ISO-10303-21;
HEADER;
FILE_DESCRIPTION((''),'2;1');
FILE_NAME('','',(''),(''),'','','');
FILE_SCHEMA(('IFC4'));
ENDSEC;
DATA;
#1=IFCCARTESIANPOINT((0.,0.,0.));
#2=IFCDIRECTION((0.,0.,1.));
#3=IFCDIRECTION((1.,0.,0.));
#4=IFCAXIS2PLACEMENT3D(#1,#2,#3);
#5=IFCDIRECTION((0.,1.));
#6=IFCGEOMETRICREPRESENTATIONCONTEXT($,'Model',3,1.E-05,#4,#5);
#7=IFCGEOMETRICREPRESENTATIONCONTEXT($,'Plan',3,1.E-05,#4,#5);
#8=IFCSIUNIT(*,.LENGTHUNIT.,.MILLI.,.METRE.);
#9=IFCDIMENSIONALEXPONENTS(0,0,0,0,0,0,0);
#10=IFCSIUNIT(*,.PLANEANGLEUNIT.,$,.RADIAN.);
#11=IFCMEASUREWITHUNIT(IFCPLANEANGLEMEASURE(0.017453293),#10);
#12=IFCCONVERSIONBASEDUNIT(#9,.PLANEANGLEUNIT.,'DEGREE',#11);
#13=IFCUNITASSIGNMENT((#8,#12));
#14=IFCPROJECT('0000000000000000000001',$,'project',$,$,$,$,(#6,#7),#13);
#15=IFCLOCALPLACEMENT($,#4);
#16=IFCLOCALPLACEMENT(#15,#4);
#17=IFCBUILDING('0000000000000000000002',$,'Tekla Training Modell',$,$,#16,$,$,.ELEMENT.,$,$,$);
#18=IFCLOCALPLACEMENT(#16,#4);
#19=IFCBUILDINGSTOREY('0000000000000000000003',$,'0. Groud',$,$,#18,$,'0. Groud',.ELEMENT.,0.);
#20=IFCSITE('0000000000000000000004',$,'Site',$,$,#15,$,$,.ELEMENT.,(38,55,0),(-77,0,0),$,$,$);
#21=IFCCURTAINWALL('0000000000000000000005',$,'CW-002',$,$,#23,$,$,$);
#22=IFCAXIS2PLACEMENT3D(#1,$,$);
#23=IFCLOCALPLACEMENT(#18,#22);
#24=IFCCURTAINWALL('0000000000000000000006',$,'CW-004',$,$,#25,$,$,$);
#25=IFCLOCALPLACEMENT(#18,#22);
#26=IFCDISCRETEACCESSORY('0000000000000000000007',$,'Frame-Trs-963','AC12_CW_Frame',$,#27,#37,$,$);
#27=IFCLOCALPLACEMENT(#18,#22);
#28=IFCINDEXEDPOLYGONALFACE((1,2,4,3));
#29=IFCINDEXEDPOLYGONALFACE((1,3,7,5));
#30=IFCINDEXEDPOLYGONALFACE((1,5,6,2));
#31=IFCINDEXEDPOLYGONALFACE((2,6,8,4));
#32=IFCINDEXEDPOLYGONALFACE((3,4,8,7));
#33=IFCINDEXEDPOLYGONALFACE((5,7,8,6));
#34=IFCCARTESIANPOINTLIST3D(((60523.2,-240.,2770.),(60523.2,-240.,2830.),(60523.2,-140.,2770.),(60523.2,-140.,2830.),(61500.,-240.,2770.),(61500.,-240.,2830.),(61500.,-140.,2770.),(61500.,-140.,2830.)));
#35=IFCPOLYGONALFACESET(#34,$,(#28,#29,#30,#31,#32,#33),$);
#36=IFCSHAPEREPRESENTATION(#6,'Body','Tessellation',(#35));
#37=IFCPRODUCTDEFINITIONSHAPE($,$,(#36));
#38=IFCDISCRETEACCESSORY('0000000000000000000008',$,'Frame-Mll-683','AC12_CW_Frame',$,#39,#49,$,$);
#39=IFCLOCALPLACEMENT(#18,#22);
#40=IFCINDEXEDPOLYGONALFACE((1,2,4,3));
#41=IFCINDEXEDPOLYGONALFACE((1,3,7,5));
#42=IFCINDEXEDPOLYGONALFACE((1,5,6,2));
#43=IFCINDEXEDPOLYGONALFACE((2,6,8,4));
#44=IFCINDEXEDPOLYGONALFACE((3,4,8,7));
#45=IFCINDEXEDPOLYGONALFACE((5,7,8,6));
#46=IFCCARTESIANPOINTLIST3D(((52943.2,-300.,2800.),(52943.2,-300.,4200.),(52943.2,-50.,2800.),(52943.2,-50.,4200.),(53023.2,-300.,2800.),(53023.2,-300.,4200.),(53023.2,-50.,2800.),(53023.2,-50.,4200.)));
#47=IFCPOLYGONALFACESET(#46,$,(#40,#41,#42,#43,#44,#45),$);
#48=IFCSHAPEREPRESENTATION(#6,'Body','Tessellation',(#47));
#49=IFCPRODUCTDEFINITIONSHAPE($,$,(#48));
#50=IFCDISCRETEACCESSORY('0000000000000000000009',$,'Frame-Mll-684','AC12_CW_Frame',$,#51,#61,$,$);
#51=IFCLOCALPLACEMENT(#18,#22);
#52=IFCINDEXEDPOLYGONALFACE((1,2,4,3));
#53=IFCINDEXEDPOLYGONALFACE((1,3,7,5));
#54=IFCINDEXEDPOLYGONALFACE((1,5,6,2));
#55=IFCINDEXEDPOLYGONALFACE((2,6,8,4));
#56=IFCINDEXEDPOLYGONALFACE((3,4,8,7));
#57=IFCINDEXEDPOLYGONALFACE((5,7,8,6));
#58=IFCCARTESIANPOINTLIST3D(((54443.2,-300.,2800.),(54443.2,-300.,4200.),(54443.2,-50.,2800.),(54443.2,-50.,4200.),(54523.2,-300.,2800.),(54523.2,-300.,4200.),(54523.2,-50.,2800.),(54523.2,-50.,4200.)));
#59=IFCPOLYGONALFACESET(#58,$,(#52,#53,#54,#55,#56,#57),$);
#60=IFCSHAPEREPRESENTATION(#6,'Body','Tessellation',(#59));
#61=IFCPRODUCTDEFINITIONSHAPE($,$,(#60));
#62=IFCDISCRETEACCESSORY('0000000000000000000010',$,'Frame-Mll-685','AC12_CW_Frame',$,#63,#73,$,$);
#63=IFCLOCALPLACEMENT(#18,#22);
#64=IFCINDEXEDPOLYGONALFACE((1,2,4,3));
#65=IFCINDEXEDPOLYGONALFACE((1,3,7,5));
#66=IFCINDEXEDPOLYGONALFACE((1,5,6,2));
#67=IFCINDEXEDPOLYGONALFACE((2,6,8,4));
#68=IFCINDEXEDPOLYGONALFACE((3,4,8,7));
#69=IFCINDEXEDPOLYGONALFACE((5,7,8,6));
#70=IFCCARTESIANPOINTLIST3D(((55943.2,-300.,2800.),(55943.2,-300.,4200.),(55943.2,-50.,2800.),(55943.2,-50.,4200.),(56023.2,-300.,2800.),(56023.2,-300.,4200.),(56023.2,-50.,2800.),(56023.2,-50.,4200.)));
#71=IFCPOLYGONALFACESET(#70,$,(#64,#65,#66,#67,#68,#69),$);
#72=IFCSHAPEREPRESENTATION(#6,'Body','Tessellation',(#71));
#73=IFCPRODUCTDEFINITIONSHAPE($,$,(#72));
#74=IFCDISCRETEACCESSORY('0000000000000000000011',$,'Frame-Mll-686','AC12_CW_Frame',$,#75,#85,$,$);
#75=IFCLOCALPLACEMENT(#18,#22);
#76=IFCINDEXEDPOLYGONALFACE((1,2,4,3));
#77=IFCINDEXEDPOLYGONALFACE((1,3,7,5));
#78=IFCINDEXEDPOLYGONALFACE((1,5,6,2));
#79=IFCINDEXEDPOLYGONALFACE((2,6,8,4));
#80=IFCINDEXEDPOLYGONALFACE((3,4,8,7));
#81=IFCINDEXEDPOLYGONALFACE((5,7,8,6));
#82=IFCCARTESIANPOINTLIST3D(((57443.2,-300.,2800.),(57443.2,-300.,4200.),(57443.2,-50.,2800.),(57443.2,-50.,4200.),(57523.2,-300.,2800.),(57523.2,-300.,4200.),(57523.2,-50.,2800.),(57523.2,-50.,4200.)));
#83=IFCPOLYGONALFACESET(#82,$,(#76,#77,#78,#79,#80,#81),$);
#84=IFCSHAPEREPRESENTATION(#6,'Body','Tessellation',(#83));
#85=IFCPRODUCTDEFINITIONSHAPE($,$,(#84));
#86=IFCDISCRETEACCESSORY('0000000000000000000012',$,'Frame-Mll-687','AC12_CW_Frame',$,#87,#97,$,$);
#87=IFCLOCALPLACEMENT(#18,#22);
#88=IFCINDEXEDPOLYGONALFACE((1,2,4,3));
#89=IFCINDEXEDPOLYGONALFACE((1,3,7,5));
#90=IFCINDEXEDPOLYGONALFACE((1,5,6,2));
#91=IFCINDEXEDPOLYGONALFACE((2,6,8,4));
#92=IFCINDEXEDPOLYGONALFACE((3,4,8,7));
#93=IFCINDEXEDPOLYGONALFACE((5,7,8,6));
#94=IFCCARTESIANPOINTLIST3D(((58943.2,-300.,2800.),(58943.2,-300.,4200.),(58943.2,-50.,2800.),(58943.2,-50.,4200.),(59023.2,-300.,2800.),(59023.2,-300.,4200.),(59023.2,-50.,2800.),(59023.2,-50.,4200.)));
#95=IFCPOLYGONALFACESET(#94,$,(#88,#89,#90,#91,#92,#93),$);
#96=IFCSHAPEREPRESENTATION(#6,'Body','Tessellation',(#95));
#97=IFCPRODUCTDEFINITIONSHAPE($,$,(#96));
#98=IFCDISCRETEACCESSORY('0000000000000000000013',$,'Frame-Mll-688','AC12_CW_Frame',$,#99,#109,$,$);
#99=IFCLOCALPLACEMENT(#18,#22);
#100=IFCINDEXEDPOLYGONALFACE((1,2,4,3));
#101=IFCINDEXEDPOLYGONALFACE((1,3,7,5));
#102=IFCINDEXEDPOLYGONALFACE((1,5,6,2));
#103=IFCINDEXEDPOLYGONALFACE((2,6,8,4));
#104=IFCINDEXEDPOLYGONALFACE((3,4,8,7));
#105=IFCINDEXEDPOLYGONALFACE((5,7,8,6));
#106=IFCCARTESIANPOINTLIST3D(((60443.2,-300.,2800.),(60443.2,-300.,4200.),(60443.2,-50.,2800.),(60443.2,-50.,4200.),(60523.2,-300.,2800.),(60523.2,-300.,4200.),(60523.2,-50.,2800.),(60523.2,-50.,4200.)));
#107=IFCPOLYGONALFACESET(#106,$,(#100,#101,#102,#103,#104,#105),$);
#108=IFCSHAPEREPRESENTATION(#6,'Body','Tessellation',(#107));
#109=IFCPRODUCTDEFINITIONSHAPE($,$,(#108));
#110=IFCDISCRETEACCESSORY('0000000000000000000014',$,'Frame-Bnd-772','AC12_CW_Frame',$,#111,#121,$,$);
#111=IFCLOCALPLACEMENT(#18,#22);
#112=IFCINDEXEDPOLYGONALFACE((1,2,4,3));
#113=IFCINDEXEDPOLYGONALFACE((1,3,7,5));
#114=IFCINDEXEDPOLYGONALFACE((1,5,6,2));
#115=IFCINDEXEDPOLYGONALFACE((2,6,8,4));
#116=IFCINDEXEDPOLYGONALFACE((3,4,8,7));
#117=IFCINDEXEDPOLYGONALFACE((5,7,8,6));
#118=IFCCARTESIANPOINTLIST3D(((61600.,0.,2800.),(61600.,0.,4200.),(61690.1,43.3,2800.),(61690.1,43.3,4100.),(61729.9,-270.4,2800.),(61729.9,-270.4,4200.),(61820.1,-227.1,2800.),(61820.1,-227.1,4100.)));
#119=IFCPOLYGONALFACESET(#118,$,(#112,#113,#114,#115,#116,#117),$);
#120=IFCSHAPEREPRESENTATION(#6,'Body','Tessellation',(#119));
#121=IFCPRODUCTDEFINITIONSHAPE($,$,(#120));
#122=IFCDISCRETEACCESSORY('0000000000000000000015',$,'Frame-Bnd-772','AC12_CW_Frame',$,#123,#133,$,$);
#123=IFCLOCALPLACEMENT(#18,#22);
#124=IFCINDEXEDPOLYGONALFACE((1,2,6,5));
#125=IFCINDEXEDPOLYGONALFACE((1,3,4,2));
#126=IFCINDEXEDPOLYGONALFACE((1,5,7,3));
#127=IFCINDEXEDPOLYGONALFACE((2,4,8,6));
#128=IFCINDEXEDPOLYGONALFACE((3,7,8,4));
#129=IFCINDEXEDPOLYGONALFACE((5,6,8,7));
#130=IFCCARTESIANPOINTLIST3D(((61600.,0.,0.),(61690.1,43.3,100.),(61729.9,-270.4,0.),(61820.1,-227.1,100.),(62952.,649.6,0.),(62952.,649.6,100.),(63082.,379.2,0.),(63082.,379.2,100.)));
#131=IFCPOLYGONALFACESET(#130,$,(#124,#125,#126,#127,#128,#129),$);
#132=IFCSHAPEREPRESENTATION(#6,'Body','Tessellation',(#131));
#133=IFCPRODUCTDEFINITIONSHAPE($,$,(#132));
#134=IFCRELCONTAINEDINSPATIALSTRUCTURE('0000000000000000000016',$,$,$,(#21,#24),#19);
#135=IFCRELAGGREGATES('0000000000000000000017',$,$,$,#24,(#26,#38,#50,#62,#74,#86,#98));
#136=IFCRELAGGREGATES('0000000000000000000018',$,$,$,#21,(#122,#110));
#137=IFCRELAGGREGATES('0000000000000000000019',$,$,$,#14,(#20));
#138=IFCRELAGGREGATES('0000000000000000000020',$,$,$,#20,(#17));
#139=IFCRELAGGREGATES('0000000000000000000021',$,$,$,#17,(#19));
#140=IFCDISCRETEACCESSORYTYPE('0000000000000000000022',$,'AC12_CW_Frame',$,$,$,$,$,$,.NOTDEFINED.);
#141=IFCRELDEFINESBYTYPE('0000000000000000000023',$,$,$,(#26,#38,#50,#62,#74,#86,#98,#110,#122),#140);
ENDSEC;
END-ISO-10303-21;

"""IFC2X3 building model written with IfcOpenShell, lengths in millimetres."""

from ifc_helpers import new_model, entity, si_unit, converted_unit, direction, frame, origin_with_axes, place, context, project, spatial, polyline, outline, extrude, source, transform, mapped, type_object, element, aggregate, save


model = new_model("IFC2X3")

# Units and contexts
model_context = context("Model", 3, precision=1e-05, world=origin_with_axes(), true_north=direction((0.0, 1.0)))
plan_context = context("Plan", 3, precision=1e-05, world=origin_with_axes(), true_north=direction((0.0, 1.0)))
ifc_project = project(units=[si_unit("LENGTHUNIT", "METRE", prefix="MILLI"), converted_unit("PLANEANGLEUNIT", "DEGREE", entity("IfcPlaneAngleMeasure", 0.017453293), si_unit("PLANEANGLEUNIT", "RADIAN"), dimensions=[0, 0, 0, 0, 0, 0, 0])], contexts=[model_context, plan_context])

# Site, building, storey
site_placement = place(None, origin_with_axes())
site = spatial("IfcSite", under=ifc_project, at=site_placement, Name="Site", CompositionType="ELEMENT", RefLatitude=(38, 55, 0), RefLongitude=(-77, 0, 0))
building_placement = place(site_placement, origin_with_axes())
building = spatial("IfcBuilding", under=site, at=building_placement, Name="Tekla Training Modell", CompositionType="ELEMENT")
storey_placement = place(building_placement, origin_with_axes())
storey = spatial("IfcBuildingStorey", under=building, at=storey_placement, Name="0. Groud", LongName="0. Groud", CompositionType="ELEMENT", Elevation=0.0)

# Curtain wall
curtain_wall_1_placement = place(storey_placement, frame((61708.3, -225.3, 0.0), z_axis=(0.0, 0.0, 1.0), x_axis=(0.901357, 0.433078, 0.0)))
curtain_wall_1 = element("IfcCurtainWall", 1, at=curtain_wall_1_placement, inside=storey, Name="CW-002")

# Curtain wall
curtain_wall_2_placement = place(storey_placement, frame((3483.2, -250.0, 0.0), z_axis=(0.0, 0.0, 1.0), x_axis=(1.0, 0.0, 0.0)))
curtain_wall_2 = element("IfcCurtainWall", 2, at=curtain_wall_2_placement, inside=storey, Name="CW-004")

# Discrete accessories
discrete_accessory_type = type_object("IfcDiscreteAccessoryType", Name="AC12_CW_Frame")
shared_shape_1 = source(origin_with_axes(), model_context, "Body", "SweptSolid", [
    extrude(outline(polyline([(0.0, 0.0), (100.0, 0.0), (100.0, -976.8), (0.0, -976.8), (0.0, 0.0)])), origin_with_axes(), (0.0, 0.0, 1.0), 60.0),
])
discrete_accessory_1_placement = place(storey_placement, frame((60523.2, -140.0, 2830.0), z_axis=(0.0, 0.0, -1.0), x_axis=(0.0, -1.0, 0.0)))
discrete_accessory_1 = element("IfcDiscreteAccessory", 3, at=discrete_accessory_1_placement, type_object=discrete_accessory_type, Name="Frame-Trs-963", Description="AC12_CW_Frame", context=model_context, shape_type="MappedRepresentation", body=[
    mapped(shared_shape_1, transform((0.0, 0.0, 0.0), scale=1.0)),
])
shared_shape_2 = source(origin_with_axes(), model_context, "Body", "SweptSolid", [
    extrude(outline(polyline([(0.0, 0.0), (250.0, 0.0), (250.0, -1400.0), (0.0, -1400.0), (0.0, 0.0)])), origin_with_axes(), (0.0, 0.0, 1.0), 80.0),
])
discrete_accessory_2_placement = place(storey_placement, frame((52943.2, -50.0, 2800.0), z_axis=(1.0, 0.0, 0.0), x_axis=(0.0, -1.0, 0.0)))
discrete_accessory_2 = element("IfcDiscreteAccessory", 4, at=discrete_accessory_2_placement, type_object=discrete_accessory_type, Name="Frame-Mll-683", Description="AC12_CW_Frame", context=model_context, shape_type="MappedRepresentation", body=[
    mapped(shared_shape_2, transform((0.0, 0.0, 0.0), scale=1.0)),
])
discrete_accessory_3_placement = place(storey_placement, frame((54443.2, -50.0, 2800.0), z_axis=(1.0, 0.0, 0.0), x_axis=(0.0, -1.0, 0.0)))
discrete_accessory_3 = element("IfcDiscreteAccessory", 5, at=discrete_accessory_3_placement, type_object=discrete_accessory_type, Name="Frame-Mll-684", Description="AC12_CW_Frame", context=model_context, shape_type="MappedRepresentation", body=[
    mapped(shared_shape_2, transform((0.0, 0.0, 0.0), scale=1.0)),
])
discrete_accessory_4_placement = place(storey_placement, frame((55943.2, -50.0, 2800.0), z_axis=(1.0, 0.0, 0.0), x_axis=(0.0, -1.0, 0.0)))
discrete_accessory_4 = element("IfcDiscreteAccessory", 6, at=discrete_accessory_4_placement, type_object=discrete_accessory_type, Name="Frame-Mll-685", Description="AC12_CW_Frame", context=model_context, shape_type="MappedRepresentation", body=[
    mapped(shared_shape_2, transform((0.0, 0.0, 0.0), scale=1.0)),
])
discrete_accessory_5_placement = place(storey_placement, frame((57443.2, -50.0, 2800.0), z_axis=(1.0, 0.0, 0.0), x_axis=(0.0, -1.0, 0.0)))
discrete_accessory_5 = element("IfcDiscreteAccessory", 7, at=discrete_accessory_5_placement, type_object=discrete_accessory_type, Name="Frame-Mll-686", Description="AC12_CW_Frame", context=model_context, shape_type="MappedRepresentation", body=[
    mapped(shared_shape_2, transform((0.0, 0.0, 0.0), scale=1.0)),
])
discrete_accessory_6_placement = place(storey_placement, frame((58943.2, -50.0, 2800.0), z_axis=(1.0, 0.0, 0.0), x_axis=(0.0, -1.0, 0.0)))
discrete_accessory_6 = element("IfcDiscreteAccessory", 8, at=discrete_accessory_6_placement, type_object=discrete_accessory_type, Name="Frame-Mll-687", Description="AC12_CW_Frame", context=model_context, shape_type="MappedRepresentation", body=[
    mapped(shared_shape_2, transform((0.0, 0.0, 0.0), scale=1.0)),
])
discrete_accessory_7_placement = place(storey_placement, frame((60443.2, -50.0, 2800.0), z_axis=(1.0, 0.0, 0.0), x_axis=(0.0, -1.0, 0.0)))
discrete_accessory_7 = element("IfcDiscreteAccessory", 9, at=discrete_accessory_7_placement, type_object=discrete_accessory_type, Name="Frame-Mll-688", Description="AC12_CW_Frame", context=model_context, shape_type="MappedRepresentation", body=[
    mapped(shared_shape_2, transform((0.0, 0.0, 0.0), scale=1.0)),
])
aggregate(curtain_wall_2, [discrete_accessory_1, discrete_accessory_2, discrete_accessory_3, discrete_accessory_4, discrete_accessory_5, discrete_accessory_6, discrete_accessory_7])
shared_shape_3 = source(origin_with_axes(), model_context, "Body", "SweptSolid", [
    extrude(outline(polyline([(0.0, 0.0), (100.0, 0.0), (100.0, -1300.0), (0.0, -1400.0), (0.0, 0.0)])), origin_with_axes(), (0.0, 0.0, 1.0), 300.0),
])
discrete_accessory_8_placement = place(storey_placement, frame((61729.9, -270.4, 2800.0), z_axis=(-0.433078, 0.901357, 0.0), x_axis=(0.901357, 0.433078, 0.0)))
discrete_accessory_8 = element("IfcDiscreteAccessory", 10, at=discrete_accessory_8_placement, type_object=discrete_accessory_type, Name="Frame-Bnd-772", Description="AC12_CW_Frame", context=model_context, shape_type="MappedRepresentation", body=[
    mapped(shared_shape_3, transform((0.0, 0.0, 0.0), scale=1.0)),
])
shared_shape_4 = source(origin_with_axes(), model_context, "Body", "SweptSolid", [
    extrude(outline(polyline([(0.0, 0.0), (141.4, 0.0), (-919.2, -1060.7), (-989.9, -989.9), (0.0, 0.0)])), origin_with_axes(), (0.0, 0.0, 1.0), 300.0),
])
discrete_accessory_9_placement = place(storey_placement, frame((61820.1, -227.1, 100.0), z_axis=(-0.433078, 0.901357, 0.0), x_axis=(-0.637355, -0.306232, -0.707107)))
discrete_accessory_9 = element("IfcDiscreteAccessory", 11, at=discrete_accessory_9_placement, type_object=discrete_accessory_type, Name="Frame-Bnd-772", Description="AC12_CW_Frame", context=model_context, shape_type="MappedRepresentation", body=[
    mapped(shared_shape_4, transform((0.0, 0.0, 0.0), scale=1.0)),
])
aggregate(curtain_wall_1, [discrete_accessory_9, discrete_accessory_8])

save(model, "model.ifc")
